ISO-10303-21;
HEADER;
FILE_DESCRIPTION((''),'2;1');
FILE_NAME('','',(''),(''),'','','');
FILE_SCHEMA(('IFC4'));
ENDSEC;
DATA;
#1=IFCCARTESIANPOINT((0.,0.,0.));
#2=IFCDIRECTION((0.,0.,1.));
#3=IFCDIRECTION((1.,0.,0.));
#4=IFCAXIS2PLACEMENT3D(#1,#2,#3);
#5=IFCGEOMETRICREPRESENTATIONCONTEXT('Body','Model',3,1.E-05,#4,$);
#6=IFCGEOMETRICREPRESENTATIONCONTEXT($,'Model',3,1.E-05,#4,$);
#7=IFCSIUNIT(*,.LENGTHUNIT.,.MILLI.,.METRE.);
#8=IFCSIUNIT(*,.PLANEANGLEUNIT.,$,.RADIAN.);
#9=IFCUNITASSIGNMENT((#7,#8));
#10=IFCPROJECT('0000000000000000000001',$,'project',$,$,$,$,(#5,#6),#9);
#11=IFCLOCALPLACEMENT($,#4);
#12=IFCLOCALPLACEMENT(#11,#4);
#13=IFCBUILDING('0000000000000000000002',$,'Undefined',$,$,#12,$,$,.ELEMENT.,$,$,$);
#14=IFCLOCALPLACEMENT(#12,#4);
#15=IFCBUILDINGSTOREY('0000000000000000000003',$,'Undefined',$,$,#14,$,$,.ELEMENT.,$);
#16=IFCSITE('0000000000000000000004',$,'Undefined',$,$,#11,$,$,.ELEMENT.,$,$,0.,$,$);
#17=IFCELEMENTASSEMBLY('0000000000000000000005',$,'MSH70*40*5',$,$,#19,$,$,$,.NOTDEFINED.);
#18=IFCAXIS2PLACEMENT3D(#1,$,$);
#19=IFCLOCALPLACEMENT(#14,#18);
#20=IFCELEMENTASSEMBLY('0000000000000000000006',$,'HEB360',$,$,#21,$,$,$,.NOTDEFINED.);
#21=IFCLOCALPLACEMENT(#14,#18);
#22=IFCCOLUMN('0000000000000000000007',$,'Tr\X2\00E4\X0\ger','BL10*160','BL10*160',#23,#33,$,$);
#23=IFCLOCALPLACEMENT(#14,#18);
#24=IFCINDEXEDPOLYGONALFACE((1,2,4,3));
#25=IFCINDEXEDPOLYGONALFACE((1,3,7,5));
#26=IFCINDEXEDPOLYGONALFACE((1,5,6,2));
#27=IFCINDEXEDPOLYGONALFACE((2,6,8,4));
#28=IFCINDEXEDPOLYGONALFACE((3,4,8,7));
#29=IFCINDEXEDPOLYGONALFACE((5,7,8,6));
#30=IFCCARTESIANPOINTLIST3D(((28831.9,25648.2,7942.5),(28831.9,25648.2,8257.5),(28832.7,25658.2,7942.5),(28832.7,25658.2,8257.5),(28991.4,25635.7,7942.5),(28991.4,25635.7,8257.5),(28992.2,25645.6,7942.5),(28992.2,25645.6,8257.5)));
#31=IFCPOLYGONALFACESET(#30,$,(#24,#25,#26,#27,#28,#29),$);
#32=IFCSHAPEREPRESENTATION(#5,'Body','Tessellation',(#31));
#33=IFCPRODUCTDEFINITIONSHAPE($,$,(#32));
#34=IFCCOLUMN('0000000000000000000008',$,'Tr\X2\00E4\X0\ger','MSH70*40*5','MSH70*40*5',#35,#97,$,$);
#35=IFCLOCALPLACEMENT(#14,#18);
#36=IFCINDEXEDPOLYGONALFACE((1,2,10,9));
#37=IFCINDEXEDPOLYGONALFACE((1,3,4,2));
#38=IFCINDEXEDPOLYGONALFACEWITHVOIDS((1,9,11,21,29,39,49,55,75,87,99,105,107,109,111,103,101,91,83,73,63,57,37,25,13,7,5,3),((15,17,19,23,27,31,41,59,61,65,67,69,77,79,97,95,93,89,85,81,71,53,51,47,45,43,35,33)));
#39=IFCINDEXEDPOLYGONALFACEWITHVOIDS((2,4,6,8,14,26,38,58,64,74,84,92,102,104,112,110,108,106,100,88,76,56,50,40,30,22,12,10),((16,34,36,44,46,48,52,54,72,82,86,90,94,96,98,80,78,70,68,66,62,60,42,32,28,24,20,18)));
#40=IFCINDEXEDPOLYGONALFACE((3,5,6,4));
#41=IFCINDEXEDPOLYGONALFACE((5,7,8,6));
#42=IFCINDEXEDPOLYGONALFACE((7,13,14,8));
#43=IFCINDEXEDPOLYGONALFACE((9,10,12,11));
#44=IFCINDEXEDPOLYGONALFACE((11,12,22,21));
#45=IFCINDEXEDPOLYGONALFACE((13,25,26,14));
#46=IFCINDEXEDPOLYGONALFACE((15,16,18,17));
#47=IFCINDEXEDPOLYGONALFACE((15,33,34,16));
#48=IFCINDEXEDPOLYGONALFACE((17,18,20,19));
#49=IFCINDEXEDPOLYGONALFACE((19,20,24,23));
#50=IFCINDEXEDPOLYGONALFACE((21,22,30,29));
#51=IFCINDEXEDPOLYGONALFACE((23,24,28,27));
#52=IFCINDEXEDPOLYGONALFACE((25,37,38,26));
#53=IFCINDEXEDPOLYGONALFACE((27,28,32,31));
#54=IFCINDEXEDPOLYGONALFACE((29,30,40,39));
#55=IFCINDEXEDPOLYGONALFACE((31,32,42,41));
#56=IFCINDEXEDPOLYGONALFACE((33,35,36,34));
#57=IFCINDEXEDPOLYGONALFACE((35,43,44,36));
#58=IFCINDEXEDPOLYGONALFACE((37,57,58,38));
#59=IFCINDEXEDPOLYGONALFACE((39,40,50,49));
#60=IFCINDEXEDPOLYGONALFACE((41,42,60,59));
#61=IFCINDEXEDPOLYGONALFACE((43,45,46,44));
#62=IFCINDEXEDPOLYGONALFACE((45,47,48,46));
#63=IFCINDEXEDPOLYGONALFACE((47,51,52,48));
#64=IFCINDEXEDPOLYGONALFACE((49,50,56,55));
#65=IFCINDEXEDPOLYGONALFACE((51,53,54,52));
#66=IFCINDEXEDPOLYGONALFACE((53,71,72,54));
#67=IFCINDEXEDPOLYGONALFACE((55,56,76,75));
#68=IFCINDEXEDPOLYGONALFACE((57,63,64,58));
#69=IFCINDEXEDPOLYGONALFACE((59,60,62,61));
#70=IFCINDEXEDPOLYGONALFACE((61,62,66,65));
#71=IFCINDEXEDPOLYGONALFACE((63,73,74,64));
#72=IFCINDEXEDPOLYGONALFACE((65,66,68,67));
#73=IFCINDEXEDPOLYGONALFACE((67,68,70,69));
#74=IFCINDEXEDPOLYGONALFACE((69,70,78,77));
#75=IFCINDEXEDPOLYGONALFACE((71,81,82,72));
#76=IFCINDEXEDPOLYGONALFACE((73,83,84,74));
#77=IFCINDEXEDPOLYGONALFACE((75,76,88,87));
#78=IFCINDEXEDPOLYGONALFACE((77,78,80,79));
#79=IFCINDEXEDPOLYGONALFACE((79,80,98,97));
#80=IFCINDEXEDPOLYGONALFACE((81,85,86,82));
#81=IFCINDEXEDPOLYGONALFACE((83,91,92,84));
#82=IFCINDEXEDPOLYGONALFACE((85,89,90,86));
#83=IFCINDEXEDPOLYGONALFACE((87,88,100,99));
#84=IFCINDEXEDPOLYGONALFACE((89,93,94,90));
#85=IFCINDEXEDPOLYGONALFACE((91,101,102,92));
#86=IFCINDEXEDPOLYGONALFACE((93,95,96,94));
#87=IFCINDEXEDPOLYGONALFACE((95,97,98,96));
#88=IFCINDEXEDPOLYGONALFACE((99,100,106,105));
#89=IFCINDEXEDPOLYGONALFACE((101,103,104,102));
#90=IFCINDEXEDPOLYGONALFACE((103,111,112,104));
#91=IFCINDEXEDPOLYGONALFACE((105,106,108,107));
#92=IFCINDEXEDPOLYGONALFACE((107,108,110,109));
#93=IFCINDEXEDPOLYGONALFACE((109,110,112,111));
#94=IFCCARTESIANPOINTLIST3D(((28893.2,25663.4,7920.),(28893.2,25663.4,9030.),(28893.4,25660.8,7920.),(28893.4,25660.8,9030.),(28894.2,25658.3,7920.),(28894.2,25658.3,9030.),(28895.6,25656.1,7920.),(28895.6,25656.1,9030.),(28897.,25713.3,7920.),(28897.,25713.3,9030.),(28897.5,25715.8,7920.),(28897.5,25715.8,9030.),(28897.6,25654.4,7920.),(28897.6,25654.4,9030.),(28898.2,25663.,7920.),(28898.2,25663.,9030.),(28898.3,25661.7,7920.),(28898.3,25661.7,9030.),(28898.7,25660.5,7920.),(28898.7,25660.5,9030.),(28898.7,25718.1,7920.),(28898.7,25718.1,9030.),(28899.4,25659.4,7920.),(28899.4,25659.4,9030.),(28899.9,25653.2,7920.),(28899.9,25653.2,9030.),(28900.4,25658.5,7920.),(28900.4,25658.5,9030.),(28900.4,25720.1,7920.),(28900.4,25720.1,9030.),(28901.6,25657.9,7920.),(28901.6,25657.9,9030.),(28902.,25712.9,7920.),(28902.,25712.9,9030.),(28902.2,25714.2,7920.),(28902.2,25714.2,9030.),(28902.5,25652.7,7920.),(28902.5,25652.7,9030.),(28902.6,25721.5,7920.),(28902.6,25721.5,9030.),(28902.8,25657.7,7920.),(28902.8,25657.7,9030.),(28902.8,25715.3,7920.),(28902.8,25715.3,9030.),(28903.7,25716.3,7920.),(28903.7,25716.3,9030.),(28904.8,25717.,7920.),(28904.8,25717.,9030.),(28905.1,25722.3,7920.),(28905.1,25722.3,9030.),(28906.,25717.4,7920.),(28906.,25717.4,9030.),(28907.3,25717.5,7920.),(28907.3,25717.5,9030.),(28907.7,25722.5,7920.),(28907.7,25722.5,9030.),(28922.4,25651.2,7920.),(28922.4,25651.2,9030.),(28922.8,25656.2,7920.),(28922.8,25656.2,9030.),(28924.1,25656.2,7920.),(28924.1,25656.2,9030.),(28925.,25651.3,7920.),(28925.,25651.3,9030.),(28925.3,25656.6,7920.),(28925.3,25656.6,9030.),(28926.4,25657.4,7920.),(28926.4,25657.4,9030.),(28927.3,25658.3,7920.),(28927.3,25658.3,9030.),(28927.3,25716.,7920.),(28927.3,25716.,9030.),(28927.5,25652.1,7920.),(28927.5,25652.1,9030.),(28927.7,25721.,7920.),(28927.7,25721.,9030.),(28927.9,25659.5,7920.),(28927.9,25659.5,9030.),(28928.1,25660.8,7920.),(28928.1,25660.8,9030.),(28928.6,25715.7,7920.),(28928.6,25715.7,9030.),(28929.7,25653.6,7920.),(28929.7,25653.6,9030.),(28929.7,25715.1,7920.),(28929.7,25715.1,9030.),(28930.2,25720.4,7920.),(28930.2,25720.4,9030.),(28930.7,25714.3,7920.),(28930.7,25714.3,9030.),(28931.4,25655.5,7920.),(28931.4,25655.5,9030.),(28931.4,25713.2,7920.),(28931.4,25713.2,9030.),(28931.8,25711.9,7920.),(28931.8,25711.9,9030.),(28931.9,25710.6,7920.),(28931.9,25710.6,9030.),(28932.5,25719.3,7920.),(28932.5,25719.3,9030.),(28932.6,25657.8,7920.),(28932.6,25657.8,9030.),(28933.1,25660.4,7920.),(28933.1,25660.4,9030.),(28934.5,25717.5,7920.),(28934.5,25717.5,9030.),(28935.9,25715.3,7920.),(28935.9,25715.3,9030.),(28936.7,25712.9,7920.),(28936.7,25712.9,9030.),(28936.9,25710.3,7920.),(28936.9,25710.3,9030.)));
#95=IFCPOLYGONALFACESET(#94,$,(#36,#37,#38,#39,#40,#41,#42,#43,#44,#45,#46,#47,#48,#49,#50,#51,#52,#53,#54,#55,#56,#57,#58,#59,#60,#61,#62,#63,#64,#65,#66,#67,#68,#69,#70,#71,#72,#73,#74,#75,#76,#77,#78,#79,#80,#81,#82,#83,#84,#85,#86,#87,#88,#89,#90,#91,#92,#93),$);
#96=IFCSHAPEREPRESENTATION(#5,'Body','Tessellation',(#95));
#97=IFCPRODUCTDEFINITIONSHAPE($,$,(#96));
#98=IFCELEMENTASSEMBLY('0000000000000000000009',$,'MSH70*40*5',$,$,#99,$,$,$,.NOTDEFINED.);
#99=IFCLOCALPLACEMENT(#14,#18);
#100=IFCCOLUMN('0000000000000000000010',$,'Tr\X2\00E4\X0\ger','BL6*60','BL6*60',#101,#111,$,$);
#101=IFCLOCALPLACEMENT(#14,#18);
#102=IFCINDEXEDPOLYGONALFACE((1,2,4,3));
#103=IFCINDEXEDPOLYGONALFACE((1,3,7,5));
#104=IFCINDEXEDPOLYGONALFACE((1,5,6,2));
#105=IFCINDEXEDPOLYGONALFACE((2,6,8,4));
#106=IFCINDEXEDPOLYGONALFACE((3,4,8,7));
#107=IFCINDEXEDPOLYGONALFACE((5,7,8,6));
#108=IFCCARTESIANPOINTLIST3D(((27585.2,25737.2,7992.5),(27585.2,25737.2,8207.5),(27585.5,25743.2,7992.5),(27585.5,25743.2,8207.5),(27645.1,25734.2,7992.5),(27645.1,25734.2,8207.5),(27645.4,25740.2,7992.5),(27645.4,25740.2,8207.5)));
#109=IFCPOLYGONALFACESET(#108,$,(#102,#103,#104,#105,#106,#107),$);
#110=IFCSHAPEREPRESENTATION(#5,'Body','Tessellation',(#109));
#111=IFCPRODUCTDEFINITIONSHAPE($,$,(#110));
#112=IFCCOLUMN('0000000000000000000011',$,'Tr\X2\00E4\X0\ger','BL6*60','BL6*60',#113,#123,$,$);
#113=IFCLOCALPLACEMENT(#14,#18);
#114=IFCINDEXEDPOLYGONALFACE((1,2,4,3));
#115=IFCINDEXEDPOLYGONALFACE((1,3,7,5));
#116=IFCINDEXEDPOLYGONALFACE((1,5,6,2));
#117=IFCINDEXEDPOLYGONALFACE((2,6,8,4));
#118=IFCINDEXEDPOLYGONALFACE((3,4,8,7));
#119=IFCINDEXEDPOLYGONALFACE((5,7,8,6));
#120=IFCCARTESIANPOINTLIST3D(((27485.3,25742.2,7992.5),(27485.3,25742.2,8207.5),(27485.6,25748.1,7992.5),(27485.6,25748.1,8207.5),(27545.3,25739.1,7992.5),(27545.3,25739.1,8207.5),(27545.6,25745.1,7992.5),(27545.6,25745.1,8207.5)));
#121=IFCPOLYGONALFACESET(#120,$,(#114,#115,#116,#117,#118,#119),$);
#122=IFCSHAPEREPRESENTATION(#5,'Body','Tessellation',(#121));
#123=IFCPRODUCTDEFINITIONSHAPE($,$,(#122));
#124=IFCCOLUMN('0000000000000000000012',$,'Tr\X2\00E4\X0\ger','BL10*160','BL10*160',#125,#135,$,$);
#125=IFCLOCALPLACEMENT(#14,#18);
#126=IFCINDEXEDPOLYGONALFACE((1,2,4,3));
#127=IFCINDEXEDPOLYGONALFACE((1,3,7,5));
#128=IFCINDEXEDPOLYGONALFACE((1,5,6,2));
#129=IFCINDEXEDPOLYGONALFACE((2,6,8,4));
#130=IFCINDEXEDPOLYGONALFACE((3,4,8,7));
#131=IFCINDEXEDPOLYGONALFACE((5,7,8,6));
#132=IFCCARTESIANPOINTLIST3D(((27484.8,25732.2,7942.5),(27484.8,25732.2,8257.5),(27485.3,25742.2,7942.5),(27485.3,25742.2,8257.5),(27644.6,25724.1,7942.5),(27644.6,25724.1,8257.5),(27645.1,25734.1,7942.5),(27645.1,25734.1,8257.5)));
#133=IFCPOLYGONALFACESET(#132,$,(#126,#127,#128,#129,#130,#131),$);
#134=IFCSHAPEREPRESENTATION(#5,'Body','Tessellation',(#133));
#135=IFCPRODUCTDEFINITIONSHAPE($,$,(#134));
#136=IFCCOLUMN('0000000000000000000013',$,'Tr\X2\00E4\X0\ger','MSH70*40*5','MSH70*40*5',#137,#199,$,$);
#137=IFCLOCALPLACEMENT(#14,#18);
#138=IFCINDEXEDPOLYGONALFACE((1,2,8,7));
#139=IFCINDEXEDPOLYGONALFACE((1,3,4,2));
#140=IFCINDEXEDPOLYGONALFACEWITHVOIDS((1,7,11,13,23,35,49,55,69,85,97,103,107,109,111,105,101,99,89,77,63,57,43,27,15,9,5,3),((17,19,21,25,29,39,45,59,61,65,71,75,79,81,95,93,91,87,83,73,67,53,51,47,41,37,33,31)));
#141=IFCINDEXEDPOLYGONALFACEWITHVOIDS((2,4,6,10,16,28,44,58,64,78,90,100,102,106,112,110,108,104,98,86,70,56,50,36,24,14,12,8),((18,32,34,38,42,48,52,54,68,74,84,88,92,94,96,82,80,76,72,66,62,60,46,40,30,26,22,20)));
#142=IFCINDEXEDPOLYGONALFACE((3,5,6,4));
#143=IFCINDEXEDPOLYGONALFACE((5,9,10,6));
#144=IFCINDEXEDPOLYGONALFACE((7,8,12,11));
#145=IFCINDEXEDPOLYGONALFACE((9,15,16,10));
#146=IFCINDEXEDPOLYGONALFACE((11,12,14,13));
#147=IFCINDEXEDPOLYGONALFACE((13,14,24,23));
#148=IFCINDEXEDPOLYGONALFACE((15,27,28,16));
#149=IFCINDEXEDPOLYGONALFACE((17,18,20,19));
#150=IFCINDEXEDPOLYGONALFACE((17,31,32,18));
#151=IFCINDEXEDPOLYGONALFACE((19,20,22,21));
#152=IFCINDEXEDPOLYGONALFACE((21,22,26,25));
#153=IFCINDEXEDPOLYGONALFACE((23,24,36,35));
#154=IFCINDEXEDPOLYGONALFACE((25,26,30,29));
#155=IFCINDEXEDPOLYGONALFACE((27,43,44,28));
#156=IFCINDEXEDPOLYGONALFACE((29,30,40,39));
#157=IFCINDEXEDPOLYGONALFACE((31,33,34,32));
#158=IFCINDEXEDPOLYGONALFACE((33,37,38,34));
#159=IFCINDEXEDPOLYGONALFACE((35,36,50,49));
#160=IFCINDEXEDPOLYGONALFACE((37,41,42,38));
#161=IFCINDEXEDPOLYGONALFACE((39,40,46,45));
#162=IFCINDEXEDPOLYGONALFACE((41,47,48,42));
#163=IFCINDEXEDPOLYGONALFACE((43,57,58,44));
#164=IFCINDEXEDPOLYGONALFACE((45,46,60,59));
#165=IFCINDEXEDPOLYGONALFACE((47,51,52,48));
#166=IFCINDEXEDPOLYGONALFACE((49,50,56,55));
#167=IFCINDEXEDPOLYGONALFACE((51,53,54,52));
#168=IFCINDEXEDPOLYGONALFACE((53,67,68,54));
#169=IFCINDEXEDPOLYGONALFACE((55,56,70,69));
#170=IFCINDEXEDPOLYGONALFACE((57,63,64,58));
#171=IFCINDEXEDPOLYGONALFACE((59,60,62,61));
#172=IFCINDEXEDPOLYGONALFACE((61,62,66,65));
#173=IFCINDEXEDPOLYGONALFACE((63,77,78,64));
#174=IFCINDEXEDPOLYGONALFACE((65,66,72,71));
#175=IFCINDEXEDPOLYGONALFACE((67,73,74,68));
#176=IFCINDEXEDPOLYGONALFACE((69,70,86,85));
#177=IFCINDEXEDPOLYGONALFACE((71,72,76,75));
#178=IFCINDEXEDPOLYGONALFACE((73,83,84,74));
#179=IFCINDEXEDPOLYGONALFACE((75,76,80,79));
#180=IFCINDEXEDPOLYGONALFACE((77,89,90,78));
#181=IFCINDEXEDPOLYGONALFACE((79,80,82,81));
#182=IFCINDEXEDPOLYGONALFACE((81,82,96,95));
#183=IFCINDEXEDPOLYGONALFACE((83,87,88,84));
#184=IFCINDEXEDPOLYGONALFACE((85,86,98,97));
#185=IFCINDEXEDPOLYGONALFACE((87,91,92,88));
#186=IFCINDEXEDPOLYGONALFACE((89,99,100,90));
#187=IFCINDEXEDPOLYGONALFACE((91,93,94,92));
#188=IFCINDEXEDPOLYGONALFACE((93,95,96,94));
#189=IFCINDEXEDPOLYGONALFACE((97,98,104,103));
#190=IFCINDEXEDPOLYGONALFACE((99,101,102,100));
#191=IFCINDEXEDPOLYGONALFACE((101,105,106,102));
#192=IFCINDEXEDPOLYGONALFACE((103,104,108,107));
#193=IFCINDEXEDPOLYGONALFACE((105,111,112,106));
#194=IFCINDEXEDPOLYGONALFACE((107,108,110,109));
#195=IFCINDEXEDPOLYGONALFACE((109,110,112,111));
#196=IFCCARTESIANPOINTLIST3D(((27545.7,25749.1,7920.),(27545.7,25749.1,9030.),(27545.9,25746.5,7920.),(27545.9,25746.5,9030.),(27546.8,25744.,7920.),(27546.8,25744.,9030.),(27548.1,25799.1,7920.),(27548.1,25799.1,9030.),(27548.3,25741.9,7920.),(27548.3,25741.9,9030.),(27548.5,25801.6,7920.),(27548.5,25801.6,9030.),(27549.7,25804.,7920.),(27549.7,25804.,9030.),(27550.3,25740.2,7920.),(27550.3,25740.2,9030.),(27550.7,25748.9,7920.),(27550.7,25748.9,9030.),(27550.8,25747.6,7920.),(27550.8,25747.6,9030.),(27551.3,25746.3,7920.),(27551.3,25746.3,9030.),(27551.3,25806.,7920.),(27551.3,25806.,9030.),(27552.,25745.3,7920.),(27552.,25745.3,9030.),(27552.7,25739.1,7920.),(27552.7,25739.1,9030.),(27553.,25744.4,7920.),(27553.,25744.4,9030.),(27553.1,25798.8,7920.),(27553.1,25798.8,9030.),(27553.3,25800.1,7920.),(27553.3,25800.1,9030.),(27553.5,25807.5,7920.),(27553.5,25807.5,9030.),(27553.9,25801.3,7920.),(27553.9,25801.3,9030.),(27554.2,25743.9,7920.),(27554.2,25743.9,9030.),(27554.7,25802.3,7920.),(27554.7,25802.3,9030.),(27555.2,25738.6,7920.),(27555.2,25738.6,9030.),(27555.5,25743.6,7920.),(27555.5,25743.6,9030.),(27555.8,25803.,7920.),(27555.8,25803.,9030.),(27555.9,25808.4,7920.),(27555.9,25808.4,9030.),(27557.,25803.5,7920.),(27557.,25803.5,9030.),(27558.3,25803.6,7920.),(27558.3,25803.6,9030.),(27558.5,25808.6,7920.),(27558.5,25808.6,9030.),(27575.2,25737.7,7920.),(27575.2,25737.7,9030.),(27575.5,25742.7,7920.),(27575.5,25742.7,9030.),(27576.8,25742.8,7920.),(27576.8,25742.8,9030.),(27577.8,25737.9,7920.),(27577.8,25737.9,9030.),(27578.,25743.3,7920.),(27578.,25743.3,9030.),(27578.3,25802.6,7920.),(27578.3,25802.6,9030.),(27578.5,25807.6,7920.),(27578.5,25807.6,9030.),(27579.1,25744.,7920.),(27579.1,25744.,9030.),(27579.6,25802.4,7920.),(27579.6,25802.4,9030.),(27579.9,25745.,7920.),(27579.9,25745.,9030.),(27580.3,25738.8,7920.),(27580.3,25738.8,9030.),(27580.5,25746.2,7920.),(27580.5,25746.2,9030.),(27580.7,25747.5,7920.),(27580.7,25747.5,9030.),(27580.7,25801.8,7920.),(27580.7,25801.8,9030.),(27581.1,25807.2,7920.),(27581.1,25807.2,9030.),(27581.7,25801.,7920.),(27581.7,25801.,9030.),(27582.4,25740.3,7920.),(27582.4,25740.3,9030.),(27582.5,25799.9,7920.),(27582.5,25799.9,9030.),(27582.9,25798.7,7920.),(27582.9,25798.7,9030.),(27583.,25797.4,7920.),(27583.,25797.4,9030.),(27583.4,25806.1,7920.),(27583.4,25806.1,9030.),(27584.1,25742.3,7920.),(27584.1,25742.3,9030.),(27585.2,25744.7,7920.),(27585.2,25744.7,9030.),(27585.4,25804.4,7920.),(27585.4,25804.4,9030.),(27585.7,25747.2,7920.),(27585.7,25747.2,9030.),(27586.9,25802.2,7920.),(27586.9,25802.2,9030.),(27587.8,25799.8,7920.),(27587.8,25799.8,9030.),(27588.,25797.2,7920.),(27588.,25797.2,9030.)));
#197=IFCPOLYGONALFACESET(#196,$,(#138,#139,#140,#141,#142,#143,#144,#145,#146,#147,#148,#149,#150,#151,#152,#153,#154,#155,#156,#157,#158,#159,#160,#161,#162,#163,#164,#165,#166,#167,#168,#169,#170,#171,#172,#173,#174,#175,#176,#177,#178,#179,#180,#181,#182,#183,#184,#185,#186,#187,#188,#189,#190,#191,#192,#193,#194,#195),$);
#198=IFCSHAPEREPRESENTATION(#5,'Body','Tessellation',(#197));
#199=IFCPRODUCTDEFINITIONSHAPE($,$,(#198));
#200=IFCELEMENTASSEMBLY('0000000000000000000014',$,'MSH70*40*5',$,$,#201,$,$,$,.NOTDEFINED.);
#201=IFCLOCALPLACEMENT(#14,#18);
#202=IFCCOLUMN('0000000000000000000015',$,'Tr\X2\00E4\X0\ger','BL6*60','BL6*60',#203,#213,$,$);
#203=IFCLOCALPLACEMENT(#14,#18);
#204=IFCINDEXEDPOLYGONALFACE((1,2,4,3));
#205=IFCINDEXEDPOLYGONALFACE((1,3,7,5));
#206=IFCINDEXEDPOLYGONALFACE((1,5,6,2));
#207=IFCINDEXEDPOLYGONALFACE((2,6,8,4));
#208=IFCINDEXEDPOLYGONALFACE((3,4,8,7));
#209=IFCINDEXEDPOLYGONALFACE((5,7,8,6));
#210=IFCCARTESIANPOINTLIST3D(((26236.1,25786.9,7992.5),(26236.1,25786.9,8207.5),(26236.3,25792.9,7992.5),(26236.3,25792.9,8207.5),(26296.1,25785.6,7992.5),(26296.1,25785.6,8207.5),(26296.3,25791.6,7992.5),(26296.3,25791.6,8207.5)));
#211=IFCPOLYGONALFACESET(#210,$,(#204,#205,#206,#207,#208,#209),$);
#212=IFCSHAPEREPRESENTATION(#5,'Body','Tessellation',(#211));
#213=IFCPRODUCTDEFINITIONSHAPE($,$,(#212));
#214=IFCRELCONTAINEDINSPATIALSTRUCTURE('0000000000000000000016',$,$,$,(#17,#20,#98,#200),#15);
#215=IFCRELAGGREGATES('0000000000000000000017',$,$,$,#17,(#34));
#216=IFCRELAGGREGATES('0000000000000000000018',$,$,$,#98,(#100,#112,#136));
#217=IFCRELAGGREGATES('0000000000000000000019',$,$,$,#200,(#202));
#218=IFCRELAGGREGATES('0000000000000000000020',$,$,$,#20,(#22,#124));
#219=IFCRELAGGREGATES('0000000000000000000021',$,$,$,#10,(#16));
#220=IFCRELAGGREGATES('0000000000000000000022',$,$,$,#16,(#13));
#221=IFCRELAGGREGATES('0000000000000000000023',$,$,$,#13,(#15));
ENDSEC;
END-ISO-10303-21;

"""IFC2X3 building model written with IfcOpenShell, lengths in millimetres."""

from ifc_helpers import new_model, si_unit, frame, origin_with_axes, origin_2d_with_axis, place, context, project, spatial, rectangle, hollow_rectangle, extrude, element, aggregate, save


model = new_model("IFC2X3")

# Units and contexts
model_context_1 = context("Model", 3, precision=1e-05, world=origin_with_axes(), identifier="Body")
model_context_2 = context("Model", 3, precision=1e-05, world=origin_with_axes())
ifc_project = project(units=[si_unit("LENGTHUNIT", "METRE", prefix="MILLI"), si_unit("PLANEANGLEUNIT", "RADIAN")], contexts=[model_context_1, model_context_2])

# Site, building, storey
site_placement = place(None, origin_with_axes())
site = spatial("IfcSite", under=ifc_project, at=site_placement, Name="Undefined", CompositionType="ELEMENT", RefElevation=0.0)
building_placement = place(site_placement, origin_with_axes())
building = spatial("IfcBuilding", under=site, at=building_placement, Name="Undefined", CompositionType="ELEMENT")
storey_placement = place(building_placement, origin_with_axes())
storey = spatial("IfcBuildingStorey", under=building, at=storey_placement, Name="Undefined", CompositionType="ELEMENT")

# Element assembly
assembly_1 = element("IfcElementAssembly", 1, inside=storey, Name="MSH70*40*5", PredefinedType="NOTDEFINED")

# Element assembly, column
assembly_2 = element("IfcElementAssembly", 2, inside=storey, Name="HEB360", PredefinedType="NOTDEFINED")
column_1_placement = place(storey_placement, frame((28912.0, 25646.9, 7942.5), z_axis=(0.0, 0.0, 1.0), x_axis=(1.0, 0.0, 0.0)))
column_1 = element("IfcColumn", 3, at=column_1_placement, Name="Träger", Description="BL10*160", ObjectType="BL10*160", context=model_context_1, shape_type="SweptSolid", body=[
    extrude(rectangle(XDim=10.0, YDim=160.0, at=origin_2d_with_axis()), frame((0.0, 0.0, 315.0), z_axis=(0.0, 0.0, -1.0), x_axis=(0.078459, 0.996917, 0.0)), (0.0, 0.0, 1.0), 315.0),
])

# Column
column_2_placement = place(storey_placement, frame((28915.1, 25686.8, 7920.0), z_axis=(0.0, 0.0, 1.0), x_axis=(1.0, 0.0, 0.0)))
column_2 = element("IfcColumn", 4, at=column_2_placement, Name="Träger", Description="MSH70*40*5", ObjectType="MSH70*40*5", context=model_context_1, shape_type="SweptSolid", body=[
    extrude(hollow_rectangle(XDim=40.0, YDim=70.0, WallThickness=5.0, InnerFilletRadius=5.0, OuterFilletRadius=10.0, at=origin_2d_with_axis()), frame((0.0, 0.0, 1110.0), z_axis=(0.0, 0.0, -1.0), x_axis=(0.997185, -0.074979, 0.000005)), (0.0, 0.0, 1.0), 1110.0),
])
aggregate(assembly_1, [column_2])

# Element assembly, columns
assembly_3 = element("IfcElementAssembly", 5, inside=storey, Name="MSH70*40*5", PredefinedType="NOTDEFINED")
column_3_placement = place(storey_placement, frame((27615.3, 25738.7, 7992.5), z_axis=(0.0, 0.0, 1.0), x_axis=(1.0, 0.0, 0.0)))
column_3 = element("IfcColumn", 6, at=column_3_placement, Name="Träger", Description="BL6*60", ObjectType="BL6*60", context=model_context_1, shape_type="SweptSolid", body=[
    extrude(rectangle(XDim=6.0, YDim=60.0, at=origin_2d_with_axis()), frame((0.0, 0.0, 215.0), z_axis=(0.0, 0.0, -1.0), x_axis=(0.050593, 0.998719, 0.0)), (0.0, 0.0, 1.0), 215.0),
])
column_4_placement = place(storey_placement, frame((27515.4, 25743.6, 7992.5), z_axis=(0.0, 0.0, 1.0), x_axis=(1.0, 0.0, 0.0)))
column_4 = element("IfcColumn", 7, at=column_4_placement, Name="Träger", Description="BL6*60", ObjectType="BL6*60", context=model_context_1, shape_type="SweptSolid", body=[
    extrude(rectangle(XDim=6.0, YDim=60.0, at=origin_2d_with_axis()), frame((0.0, 0.0, 215.0), z_axis=(0.0, 0.0, -1.0), x_axis=(0.050593, 0.998719, 0.0)), (0.0, 0.0, 1.0), 215.0),
])

# Columns
column_5_placement = place(storey_placement, frame((27565.0, 25733.2, 7942.5), z_axis=(0.0, 0.0, 1.0), x_axis=(1.0, 0.0, 0.0)))
column_5 = element("IfcColumn", 8, at=column_5_placement, Name="Träger", Description="BL10*160", ObjectType="BL10*160", context=model_context_1, shape_type="SweptSolid", body=[
    extrude(rectangle(XDim=10.0, YDim=160.0, at=origin_2d_with_axis()), frame((0.0, 0.0, 315.0), z_axis=(0.0, 0.0, -1.0), x_axis=(0.050593, 0.998719, 0.0)), (0.0, 0.0, 1.0), 315.0),
])
column_6_placement = place(storey_placement, frame((27566.9, 25773.1, 7920.0), z_axis=(0.0, 0.0, 1.0), x_axis=(1.0, 0.0, 0.0)))
column_6 = element("IfcColumn", 9, at=column_6_placement, Name="Träger", Description="MSH70*40*5", ObjectType="MSH70*40*5", context=model_context_1, shape_type="SweptSolid", body=[
    extrude(hollow_rectangle(XDim=40.0, YDim=70.0, WallThickness=5.0, InnerFilletRadius=5.0, OuterFilletRadius=10.0, at=origin_2d_with_axis()), frame((0.0, 0.0, 1110.0), z_axis=(0.0, 0.0, -1.0), x_axis=(0.99889, -0.047106, 0.000005)), (0.0, 0.0, 1.0), 1110.0),
])
aggregate(assembly_3, [column_3, column_4, column_6])

# Element assembly, column
assembly_4 = element("IfcElementAssembly", 10, inside=storey, Name="MSH70*40*5", PredefinedType="NOTDEFINED")
column_7_placement = place(storey_placement, frame((26266.2, 25789.3, 7992.5), z_axis=(0.0, 0.0, 1.0), x_axis=(1.0, 0.0, 0.0)))
column_7 = element("IfcColumn", 11, at=column_7_placement, Name="Träger", Description="BL6*60", ObjectType="BL6*60", context=model_context_1, shape_type="SweptSolid", body=[
    extrude(rectangle(XDim=6.0, YDim=60.0, at=origin_2d_with_axis()), frame((0.0, 0.0, 215.0), z_axis=(0.0, 0.0, -1.0), x_axis=(0.022687, 0.999743, 0.0)), (0.0, 0.0, 1.0), 215.0),
])

aggregate(assembly_4, [column_7])
aggregate(assembly_2, [column_1, column_5])

save(model, "model.ifc")
